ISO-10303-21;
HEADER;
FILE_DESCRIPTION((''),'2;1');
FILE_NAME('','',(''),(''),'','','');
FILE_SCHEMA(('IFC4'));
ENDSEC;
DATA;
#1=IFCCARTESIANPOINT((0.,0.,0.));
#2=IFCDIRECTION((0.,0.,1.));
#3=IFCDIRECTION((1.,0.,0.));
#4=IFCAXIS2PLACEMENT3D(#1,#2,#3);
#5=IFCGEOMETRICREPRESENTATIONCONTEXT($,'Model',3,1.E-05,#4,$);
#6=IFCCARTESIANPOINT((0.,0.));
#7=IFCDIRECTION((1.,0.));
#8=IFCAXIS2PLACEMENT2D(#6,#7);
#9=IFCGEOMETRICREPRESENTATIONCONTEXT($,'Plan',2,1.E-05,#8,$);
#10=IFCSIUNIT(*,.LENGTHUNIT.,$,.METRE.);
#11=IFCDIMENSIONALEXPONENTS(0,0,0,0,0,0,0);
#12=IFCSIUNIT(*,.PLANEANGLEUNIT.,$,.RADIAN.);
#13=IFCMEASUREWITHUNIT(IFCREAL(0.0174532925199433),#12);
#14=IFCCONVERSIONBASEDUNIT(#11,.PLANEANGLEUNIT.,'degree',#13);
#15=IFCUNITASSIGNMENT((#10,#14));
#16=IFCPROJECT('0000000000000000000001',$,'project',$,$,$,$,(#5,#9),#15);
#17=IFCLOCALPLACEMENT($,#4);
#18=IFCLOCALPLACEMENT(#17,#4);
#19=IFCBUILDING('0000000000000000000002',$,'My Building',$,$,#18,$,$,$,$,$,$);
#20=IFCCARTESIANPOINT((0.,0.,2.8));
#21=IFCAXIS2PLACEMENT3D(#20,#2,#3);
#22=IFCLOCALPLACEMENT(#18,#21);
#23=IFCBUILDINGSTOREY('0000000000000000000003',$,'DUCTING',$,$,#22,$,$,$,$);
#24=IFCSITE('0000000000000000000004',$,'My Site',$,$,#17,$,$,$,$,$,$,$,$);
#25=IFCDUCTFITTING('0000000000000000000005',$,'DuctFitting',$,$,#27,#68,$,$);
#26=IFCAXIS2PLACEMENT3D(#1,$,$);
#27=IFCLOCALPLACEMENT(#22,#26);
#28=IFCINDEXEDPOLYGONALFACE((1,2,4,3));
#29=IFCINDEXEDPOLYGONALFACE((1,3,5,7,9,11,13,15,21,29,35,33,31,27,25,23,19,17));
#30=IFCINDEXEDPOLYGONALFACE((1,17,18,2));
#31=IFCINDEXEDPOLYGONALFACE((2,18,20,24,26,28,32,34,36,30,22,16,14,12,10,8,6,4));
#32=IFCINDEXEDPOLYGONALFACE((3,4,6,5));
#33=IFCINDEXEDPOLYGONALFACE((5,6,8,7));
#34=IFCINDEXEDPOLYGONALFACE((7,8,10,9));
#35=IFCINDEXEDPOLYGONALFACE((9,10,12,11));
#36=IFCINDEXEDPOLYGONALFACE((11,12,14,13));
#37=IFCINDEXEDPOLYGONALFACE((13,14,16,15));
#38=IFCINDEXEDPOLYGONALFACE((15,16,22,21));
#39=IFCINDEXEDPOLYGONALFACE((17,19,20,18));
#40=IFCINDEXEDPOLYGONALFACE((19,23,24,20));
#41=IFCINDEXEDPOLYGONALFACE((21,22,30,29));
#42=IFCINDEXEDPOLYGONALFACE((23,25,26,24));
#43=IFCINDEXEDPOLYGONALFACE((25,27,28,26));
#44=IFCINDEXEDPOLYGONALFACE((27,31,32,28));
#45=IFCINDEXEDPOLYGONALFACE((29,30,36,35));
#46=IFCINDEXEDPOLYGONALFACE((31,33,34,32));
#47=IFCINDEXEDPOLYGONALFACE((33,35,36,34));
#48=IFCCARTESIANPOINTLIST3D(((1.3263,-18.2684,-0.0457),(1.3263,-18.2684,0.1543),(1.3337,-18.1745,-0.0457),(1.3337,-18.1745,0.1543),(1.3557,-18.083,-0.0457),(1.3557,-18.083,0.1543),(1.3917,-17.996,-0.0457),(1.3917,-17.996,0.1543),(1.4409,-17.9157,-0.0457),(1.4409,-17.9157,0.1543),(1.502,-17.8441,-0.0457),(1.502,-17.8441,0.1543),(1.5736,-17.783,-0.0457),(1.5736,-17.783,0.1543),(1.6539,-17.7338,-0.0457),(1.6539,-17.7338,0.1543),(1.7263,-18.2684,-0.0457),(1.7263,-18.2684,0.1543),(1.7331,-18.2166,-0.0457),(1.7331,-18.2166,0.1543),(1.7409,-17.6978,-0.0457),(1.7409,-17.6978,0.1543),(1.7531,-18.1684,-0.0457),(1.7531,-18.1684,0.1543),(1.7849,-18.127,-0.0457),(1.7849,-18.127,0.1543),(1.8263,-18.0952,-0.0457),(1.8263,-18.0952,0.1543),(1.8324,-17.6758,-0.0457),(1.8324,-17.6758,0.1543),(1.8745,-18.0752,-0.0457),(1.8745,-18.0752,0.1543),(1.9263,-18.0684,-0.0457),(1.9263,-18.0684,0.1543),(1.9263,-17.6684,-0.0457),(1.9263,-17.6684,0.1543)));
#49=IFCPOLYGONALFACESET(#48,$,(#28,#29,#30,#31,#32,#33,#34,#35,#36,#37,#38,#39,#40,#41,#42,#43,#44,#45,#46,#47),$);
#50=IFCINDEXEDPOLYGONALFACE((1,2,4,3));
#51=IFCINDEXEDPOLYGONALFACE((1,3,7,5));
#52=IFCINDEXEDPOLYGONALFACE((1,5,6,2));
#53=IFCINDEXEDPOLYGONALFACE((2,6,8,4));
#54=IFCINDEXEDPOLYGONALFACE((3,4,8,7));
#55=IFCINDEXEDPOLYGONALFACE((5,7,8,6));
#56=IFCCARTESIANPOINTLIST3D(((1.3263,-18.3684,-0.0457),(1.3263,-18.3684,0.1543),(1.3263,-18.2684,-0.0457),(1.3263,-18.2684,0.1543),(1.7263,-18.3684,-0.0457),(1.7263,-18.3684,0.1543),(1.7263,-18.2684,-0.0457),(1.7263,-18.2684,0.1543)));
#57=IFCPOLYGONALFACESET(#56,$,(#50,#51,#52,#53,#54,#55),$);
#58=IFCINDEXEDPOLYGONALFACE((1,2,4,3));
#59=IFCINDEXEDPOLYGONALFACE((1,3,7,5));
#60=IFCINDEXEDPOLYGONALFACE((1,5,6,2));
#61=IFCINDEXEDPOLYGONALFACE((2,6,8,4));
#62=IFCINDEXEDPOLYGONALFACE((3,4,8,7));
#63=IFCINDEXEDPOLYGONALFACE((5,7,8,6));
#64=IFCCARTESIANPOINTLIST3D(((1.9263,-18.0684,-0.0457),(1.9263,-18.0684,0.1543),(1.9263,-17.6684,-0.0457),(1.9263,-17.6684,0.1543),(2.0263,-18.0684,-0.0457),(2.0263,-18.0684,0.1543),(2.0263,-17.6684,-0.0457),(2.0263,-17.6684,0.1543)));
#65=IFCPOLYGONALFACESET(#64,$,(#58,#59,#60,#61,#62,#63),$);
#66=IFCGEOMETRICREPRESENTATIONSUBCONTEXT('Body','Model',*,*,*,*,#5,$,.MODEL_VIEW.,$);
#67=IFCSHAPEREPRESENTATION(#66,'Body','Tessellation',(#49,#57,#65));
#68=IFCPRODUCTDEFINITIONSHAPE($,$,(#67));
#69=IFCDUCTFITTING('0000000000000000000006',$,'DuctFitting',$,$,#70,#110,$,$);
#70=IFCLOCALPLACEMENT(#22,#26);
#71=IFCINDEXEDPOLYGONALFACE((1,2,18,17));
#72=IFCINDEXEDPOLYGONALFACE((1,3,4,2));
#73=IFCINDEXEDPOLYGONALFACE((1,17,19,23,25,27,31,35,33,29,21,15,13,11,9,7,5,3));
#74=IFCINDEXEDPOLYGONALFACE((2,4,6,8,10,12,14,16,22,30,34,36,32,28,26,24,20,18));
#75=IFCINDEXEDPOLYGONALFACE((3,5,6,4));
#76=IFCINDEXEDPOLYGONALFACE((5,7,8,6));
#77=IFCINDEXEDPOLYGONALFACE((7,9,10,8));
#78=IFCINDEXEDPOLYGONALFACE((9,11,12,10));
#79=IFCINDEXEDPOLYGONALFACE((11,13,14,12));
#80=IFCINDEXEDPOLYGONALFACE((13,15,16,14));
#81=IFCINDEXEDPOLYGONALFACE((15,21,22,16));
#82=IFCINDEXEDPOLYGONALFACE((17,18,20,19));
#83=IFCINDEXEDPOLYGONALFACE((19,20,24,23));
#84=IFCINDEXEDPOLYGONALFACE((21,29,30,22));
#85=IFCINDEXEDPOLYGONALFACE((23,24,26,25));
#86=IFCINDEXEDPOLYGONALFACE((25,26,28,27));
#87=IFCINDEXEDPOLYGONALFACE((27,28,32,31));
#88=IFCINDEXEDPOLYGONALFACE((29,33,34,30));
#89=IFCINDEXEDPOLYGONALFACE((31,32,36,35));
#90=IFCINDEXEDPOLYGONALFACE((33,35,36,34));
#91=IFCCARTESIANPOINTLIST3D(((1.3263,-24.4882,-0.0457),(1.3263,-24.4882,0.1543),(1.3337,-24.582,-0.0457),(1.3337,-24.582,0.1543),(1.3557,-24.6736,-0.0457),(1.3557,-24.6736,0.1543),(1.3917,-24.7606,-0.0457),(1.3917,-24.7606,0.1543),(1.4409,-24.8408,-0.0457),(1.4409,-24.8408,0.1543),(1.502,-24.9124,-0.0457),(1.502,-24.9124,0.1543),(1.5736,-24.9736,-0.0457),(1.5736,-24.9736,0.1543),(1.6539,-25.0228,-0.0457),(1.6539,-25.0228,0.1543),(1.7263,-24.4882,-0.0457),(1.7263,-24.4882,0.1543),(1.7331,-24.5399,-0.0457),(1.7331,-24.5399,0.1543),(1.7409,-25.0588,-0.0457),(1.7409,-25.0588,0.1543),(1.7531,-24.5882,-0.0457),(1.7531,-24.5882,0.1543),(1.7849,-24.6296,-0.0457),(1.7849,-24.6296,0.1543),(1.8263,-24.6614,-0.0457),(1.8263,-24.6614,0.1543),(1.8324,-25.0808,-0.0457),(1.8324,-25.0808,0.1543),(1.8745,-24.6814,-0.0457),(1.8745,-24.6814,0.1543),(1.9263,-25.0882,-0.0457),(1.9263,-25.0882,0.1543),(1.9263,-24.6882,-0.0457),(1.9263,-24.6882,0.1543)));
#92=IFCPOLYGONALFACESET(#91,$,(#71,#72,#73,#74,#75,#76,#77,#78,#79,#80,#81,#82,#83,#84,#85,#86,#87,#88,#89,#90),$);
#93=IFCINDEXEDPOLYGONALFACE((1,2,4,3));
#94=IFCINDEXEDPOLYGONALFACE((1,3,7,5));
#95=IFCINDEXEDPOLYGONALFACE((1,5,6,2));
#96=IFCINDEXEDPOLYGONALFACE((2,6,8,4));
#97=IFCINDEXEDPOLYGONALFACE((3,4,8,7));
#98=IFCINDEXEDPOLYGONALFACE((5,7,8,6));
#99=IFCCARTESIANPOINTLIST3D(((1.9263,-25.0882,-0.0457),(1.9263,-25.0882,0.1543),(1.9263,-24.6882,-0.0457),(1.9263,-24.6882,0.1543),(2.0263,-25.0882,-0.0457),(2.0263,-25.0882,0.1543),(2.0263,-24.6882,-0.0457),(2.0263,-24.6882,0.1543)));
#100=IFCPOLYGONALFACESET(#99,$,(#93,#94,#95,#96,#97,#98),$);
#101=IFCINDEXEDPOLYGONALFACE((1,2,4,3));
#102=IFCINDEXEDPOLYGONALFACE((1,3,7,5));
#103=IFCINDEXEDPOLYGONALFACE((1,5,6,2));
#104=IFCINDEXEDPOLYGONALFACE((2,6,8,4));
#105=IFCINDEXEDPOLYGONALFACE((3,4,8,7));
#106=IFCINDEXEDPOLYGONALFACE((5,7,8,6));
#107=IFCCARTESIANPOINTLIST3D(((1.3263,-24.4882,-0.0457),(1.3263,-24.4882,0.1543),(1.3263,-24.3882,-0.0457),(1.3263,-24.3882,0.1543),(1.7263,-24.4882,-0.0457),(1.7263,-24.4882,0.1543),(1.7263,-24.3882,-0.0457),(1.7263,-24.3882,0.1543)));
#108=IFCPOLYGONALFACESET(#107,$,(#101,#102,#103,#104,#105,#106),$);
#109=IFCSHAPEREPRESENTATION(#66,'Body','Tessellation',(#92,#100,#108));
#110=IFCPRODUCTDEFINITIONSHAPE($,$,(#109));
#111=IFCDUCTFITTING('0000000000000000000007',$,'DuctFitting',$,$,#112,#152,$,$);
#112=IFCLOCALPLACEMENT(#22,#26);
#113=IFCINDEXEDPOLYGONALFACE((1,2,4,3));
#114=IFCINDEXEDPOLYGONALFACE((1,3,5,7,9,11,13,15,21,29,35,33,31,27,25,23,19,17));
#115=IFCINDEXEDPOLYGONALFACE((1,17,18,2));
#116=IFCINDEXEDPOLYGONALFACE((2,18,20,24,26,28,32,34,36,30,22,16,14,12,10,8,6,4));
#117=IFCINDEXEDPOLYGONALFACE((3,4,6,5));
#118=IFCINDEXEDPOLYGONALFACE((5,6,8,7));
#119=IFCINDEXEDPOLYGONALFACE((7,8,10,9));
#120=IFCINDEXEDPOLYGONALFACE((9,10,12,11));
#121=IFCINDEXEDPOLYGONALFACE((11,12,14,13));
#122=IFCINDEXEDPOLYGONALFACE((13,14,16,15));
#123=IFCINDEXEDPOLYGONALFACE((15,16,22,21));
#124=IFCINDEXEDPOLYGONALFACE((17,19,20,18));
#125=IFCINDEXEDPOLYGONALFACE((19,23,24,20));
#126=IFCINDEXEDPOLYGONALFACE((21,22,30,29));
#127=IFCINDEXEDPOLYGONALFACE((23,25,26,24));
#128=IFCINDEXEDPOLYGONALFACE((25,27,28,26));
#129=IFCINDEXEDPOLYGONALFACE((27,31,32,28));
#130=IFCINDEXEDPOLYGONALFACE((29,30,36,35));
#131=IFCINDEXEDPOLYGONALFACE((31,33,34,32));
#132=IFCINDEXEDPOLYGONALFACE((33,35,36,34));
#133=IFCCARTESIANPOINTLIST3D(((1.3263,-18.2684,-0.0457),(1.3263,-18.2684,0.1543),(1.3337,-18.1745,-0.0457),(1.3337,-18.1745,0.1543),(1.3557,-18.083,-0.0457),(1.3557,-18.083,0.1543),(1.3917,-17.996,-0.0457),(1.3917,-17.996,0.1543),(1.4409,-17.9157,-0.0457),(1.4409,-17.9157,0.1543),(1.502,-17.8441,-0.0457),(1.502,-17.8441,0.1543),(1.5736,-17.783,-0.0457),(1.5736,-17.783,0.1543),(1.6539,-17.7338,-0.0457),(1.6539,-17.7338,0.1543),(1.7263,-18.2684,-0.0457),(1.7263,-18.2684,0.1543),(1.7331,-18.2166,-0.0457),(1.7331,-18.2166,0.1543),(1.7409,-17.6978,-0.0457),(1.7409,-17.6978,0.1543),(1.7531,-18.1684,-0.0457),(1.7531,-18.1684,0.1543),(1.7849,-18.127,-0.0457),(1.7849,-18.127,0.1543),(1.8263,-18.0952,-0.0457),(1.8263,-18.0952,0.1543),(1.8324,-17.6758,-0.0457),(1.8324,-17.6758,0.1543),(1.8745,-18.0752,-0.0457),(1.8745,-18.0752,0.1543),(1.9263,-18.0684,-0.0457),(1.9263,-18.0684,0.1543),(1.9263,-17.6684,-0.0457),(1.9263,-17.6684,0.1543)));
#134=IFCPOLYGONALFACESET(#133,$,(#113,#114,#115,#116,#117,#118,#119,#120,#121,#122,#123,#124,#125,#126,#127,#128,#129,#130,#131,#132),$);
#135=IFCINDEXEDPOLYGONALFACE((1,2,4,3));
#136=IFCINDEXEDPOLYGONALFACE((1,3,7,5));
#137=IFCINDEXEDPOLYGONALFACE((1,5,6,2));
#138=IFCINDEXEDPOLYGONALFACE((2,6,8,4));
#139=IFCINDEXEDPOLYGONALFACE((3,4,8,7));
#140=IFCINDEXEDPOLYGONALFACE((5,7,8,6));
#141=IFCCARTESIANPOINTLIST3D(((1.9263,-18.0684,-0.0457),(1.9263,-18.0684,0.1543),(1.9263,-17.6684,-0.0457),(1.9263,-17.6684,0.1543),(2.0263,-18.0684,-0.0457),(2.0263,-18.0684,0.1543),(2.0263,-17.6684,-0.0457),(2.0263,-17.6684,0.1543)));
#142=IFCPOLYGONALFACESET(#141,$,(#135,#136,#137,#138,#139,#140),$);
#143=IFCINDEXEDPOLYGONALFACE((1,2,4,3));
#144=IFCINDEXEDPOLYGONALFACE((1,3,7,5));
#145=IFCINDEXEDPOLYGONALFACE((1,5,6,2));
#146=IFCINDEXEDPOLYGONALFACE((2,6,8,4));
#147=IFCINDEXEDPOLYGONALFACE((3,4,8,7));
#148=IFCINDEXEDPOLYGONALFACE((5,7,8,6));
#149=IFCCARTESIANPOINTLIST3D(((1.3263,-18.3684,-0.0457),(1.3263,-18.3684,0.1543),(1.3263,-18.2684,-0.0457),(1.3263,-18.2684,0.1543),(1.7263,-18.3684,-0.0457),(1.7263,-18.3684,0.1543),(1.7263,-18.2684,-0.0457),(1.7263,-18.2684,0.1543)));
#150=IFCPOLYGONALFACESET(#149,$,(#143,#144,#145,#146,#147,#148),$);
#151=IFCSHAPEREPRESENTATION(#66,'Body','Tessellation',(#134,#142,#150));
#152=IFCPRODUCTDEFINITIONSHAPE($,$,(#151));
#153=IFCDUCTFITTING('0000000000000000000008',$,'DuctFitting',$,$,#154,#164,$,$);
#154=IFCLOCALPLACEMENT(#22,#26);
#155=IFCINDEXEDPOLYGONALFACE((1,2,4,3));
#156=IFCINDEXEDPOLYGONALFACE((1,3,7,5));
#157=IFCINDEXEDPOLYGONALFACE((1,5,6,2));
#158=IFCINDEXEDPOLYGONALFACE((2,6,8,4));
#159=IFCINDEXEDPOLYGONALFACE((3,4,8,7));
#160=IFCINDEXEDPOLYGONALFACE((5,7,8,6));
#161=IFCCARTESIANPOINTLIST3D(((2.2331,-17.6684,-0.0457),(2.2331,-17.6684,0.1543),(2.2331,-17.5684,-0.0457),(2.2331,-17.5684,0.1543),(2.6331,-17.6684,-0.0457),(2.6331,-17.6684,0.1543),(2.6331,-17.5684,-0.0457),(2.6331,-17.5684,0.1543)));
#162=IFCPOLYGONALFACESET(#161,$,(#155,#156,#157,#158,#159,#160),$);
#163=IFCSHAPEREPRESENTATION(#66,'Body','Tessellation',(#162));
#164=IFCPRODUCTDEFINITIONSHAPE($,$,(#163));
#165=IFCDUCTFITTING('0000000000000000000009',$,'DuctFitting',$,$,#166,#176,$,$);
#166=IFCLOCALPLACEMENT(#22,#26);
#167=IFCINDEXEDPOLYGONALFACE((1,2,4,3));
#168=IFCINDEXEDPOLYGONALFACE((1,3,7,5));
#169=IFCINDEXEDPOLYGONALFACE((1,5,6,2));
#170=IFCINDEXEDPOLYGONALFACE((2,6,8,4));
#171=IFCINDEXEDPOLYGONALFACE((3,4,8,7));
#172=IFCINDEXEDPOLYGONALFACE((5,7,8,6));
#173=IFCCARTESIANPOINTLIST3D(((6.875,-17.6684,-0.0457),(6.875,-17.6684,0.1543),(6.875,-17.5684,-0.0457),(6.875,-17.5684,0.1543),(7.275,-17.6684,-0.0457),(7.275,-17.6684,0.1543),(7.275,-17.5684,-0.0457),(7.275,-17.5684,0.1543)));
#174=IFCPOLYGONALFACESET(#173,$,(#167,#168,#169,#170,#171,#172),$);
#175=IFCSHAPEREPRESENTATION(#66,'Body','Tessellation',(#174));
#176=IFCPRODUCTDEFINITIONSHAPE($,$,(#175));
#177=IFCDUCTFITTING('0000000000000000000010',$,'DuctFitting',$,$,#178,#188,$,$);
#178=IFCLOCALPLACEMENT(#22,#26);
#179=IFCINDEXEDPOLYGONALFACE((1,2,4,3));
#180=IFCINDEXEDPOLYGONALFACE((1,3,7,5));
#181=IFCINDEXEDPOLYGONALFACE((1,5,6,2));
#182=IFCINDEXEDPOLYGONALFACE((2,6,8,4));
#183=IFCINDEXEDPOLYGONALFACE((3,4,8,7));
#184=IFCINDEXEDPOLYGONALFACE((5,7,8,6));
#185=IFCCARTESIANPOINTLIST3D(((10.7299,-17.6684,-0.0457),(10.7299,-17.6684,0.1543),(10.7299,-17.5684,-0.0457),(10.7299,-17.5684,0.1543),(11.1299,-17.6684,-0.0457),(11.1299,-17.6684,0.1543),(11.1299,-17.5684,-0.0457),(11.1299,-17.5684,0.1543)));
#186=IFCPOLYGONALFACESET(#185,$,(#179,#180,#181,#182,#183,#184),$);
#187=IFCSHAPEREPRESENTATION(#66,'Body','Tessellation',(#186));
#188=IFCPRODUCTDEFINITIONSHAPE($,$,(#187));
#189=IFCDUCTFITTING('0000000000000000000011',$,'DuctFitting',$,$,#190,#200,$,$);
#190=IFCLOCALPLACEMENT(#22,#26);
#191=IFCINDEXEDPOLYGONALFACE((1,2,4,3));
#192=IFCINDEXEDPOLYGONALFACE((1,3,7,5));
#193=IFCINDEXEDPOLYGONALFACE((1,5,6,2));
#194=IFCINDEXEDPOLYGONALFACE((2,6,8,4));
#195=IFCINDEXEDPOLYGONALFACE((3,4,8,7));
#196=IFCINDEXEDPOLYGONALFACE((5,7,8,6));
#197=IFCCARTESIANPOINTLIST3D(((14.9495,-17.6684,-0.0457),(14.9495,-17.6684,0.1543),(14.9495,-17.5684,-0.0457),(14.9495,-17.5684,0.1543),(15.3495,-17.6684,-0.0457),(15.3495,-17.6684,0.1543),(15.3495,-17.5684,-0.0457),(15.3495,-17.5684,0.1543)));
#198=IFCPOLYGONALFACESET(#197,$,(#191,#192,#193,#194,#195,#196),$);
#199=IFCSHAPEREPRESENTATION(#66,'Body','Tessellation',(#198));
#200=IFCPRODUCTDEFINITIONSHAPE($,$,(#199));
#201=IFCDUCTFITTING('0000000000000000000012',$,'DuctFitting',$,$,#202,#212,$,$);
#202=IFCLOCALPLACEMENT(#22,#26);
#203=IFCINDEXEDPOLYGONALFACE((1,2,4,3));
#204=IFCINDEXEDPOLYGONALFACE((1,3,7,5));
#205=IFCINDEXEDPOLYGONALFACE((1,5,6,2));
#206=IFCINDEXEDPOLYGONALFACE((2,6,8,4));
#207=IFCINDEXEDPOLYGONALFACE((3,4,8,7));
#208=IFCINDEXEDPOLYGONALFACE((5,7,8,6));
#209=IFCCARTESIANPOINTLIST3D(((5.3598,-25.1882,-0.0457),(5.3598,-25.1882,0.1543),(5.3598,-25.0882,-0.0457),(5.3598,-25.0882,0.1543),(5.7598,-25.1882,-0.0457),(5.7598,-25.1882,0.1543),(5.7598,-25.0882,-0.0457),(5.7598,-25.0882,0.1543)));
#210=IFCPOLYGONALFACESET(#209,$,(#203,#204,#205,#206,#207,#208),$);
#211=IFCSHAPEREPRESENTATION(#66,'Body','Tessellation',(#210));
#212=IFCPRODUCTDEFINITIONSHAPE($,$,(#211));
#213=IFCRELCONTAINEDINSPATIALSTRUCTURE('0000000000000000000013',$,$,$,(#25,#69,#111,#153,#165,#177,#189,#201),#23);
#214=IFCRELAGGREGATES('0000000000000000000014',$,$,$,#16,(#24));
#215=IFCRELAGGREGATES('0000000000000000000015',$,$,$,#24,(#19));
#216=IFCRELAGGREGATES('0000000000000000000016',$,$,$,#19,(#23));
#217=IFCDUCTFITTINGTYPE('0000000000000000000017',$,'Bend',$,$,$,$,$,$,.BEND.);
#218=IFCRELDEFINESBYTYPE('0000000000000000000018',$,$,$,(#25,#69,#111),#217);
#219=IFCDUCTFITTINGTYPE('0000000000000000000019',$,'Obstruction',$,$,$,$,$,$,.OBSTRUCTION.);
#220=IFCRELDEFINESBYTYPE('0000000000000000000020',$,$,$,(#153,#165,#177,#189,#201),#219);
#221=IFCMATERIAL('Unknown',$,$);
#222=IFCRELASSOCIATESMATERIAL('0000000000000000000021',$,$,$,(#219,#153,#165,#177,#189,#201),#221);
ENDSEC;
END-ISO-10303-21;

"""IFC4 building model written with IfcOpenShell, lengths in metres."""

from ifc_helpers import new_model, entity, si_unit, converted_unit, frame, origin_with_axes, origin_2d_with_axis, place, context, subcontext, project, spatial, line, arc, indexed_curve, rectangle, outline, extrude, source, transform, mapped, material, material_profile, profile_set, profile_usage, type_object, type_shapes, element, save


model = new_model("IFC4")

# Units and contexts
model_context = context("Model", 3, precision=1e-05, world=origin_with_axes())
plan_context = context("Plan", 2, precision=1e-05, world=origin_2d_with_axis())
body_context = subcontext(model_context, "Body", "Model", "MODEL_VIEW")
ifc_project = project(units=[si_unit("LENGTHUNIT", "METRE"), converted_unit("PLANEANGLEUNIT", "degree", entity("IfcReal", 0.0174532925199433), si_unit("PLANEANGLEUNIT", "RADIAN"), dimensions=[0, 0, 0, 0, 0, 0, 0])], contexts=[model_context, plan_context])

# Site, building, storey
site_placement = place(None, origin_with_axes())
site = spatial("IfcSite", under=ifc_project, at=site_placement, Name="My Site")
building_placement = place(site_placement, origin_with_axes())
building = spatial("IfcBuilding", under=site, at=building_placement, Name="My Building")
storey_placement = place(building_placement, frame((0.0, 0.0, 2.8), z_axis=(0.0, 0.0, 1.0), x_axis=(1.0, 0.0, 0.0)))
storey = spatial("IfcBuildingStorey", under=building, at=storey_placement, Name="DUCTING")

# Shared definitions
ifc_material = material(Name="Unknown")

# Duct fittings
duct_fitting_type_1 = type_object("IfcDuctFittingType", Name="Bend", PredefinedType="BEND")
shared_shape = source(origin_with_axes(), body_context, "Body", "SweptSolid", [
    extrude(outline(indexed_curve([(0.2, 0.0), (0.2586, -0.1414), (0.4, -0.2), (0.4, -0.6), (-0.0243, -0.4243), (-0.2, 0.0)], segments=[arc(1, 2, 3), line(3, 4), arc(4, 5, 6), line(6, 1)])), frame((0.0, -0.1, -0.1), z_axis=(0.0, -1.0, 0.0), x_axis=(1.0, 0.0, 0.0)), (0.0, 0.0, -1.0), 0.2),
    extrude(rectangle(XDim=0.4, YDim=0.2), origin_with_axes(), (0.0, 0.0, -1.0), 0.1),
    extrude(rectangle(XDim=0.4, YDim=0.2), frame((0.4, 0.0, -0.5), z_axis=(1.0, 0.0, 0.0), x_axis=(0.0, 0.0, 1.0)), (0.0, 0.0, 1.0), 0.1),
])
type_shapes(duct_fitting_type_1, [shared_shape])
for number, where, z_axis, x_axis, name in (
    (1, (1.5263, -18.3684, 0.0543), (0.0, -1.0, 0.0), (1.0, 0.0, 0.0), "DuctFitting"),
    (2, (2.0263, -24.8882, 0.0543), (1.0, 0.0, 0.0), (0.0, 1.0, 0.0), "DuctFitting"),
    (3, (2.0263, -17.8684, 0.0543), (1.0, 0.0, 0.0), (0.0, -1.0, 0.0), "DuctFitting"),
):
    element("IfcDuctFitting", number, at=place(storey_placement, frame(where, z_axis=z_axis, x_axis=x_axis)), inside=storey, type_object=duct_fitting_type_1, Name=name, context=body_context, shape_type="MappedRepresentation", body=[
        mapped(shared_shape, transform((0.0, 0.0, 0.0), x_axis=(1.0, 0.0, 0.0), y_axis=(0.0, 1.0, 0.0), z_axis=(0.0, 0.0, 1.0), scale=1.0)),
    ])
ifc_material_profile_1 = material_profile(ifc_material, rectangle(XDim=0.4, YDim=0.2))
ifc_profile_set_1 = profile_set([ifc_material_profile_1])
ifc_profile_usage_1 = profile_usage(ifc_profile_set_1, cardinal=5)
duct_fitting_type_2 = type_object("IfcDuctFittingType", Name="Obstruction", PredefinedType="OBSTRUCTION", material=ifc_profile_set_1)
duct_fitting_1_placement = place(storey_placement, frame((2.4331, -17.5684, 0.0543), z_axis=(0.0, -1.0, 0.0), x_axis=(1.0, 0.0, 0.0)))
element("IfcDuctFitting", 4, at=duct_fitting_1_placement, inside=storey, type_object=duct_fitting_type_2, material=ifc_profile_usage_1, Name="DuctFitting", context=body_context, shape_type="SweptSolid", body=[
    extrude(rectangle(XDim=0.4, YDim=0.2), origin_with_axes(), (0.0, 0.0, 1.0), 0.1),
])
ifc_profile_usage_2 = profile_usage(ifc_profile_set_1, cardinal=5)
duct_fitting_2_placement = place(storey_placement, frame((7.075, -17.5684, 0.0543), z_axis=(0.0, -1.0, 0.0), x_axis=(1.0, 0.0, 0.0)))
element("IfcDuctFitting", 5, at=duct_fitting_2_placement, inside=storey, type_object=duct_fitting_type_2, material=ifc_profile_usage_2, Name="DuctFitting", context=body_context, shape_type="SweptSolid", body=[
    extrude(rectangle(XDim=0.4, YDim=0.2), origin_with_axes(), (0.0, 0.0, 1.0), 0.1),
])
ifc_profile_usage_3 = profile_usage(ifc_profile_set_1, cardinal=5)
duct_fitting_3_placement = place(storey_placement, frame((10.9299, -17.5684, 0.0543), z_axis=(0.0, -1.0, 0.0), x_axis=(1.0, 0.0, 0.0)))
element("IfcDuctFitting", 6, at=duct_fitting_3_placement, inside=storey, type_object=duct_fitting_type_2, material=ifc_profile_usage_3, Name="DuctFitting", context=body_context, shape_type="SweptSolid", body=[
    extrude(rectangle(XDim=0.4, YDim=0.2), origin_with_axes(), (0.0, 0.0, 1.0), 0.1),
])
ifc_profile_usage_4 = profile_usage(ifc_profile_set_1, cardinal=5)
duct_fitting_4_placement = place(storey_placement, frame((15.1495, -17.5684, 0.0543), z_axis=(0.0, -1.0, 0.0), x_axis=(1.0, 0.0, 0.0)))
element("IfcDuctFitting", 7, at=duct_fitting_4_placement, inside=storey, type_object=duct_fitting_type_2, material=ifc_profile_usage_4, Name="DuctFitting", context=body_context, shape_type="SweptSolid", body=[
    extrude(rectangle(XDim=0.4, YDim=0.2), origin_with_axes(), (0.0, 0.0, 1.0), 0.1),
])
ifc_profile_usage_5 = profile_usage(ifc_profile_set_1, cardinal=5)
duct_fitting_5_placement = place(storey_placement, frame((5.5598, -25.1882, 0.0543), z_axis=(0.0, 1.0, 0.0), x_axis=(-1.0, 0.0, 0.0)))
element("IfcDuctFitting", 8, at=duct_fitting_5_placement, inside=storey, type_object=duct_fitting_type_2, material=ifc_profile_usage_5, Name="DuctFitting", context=body_context, shape_type="SweptSolid", body=[
    extrude(rectangle(XDim=0.4, YDim=0.2), origin_with_axes(), (0.0, 0.0, 1.0), 0.1),
])

save(model, "model.ifc")
